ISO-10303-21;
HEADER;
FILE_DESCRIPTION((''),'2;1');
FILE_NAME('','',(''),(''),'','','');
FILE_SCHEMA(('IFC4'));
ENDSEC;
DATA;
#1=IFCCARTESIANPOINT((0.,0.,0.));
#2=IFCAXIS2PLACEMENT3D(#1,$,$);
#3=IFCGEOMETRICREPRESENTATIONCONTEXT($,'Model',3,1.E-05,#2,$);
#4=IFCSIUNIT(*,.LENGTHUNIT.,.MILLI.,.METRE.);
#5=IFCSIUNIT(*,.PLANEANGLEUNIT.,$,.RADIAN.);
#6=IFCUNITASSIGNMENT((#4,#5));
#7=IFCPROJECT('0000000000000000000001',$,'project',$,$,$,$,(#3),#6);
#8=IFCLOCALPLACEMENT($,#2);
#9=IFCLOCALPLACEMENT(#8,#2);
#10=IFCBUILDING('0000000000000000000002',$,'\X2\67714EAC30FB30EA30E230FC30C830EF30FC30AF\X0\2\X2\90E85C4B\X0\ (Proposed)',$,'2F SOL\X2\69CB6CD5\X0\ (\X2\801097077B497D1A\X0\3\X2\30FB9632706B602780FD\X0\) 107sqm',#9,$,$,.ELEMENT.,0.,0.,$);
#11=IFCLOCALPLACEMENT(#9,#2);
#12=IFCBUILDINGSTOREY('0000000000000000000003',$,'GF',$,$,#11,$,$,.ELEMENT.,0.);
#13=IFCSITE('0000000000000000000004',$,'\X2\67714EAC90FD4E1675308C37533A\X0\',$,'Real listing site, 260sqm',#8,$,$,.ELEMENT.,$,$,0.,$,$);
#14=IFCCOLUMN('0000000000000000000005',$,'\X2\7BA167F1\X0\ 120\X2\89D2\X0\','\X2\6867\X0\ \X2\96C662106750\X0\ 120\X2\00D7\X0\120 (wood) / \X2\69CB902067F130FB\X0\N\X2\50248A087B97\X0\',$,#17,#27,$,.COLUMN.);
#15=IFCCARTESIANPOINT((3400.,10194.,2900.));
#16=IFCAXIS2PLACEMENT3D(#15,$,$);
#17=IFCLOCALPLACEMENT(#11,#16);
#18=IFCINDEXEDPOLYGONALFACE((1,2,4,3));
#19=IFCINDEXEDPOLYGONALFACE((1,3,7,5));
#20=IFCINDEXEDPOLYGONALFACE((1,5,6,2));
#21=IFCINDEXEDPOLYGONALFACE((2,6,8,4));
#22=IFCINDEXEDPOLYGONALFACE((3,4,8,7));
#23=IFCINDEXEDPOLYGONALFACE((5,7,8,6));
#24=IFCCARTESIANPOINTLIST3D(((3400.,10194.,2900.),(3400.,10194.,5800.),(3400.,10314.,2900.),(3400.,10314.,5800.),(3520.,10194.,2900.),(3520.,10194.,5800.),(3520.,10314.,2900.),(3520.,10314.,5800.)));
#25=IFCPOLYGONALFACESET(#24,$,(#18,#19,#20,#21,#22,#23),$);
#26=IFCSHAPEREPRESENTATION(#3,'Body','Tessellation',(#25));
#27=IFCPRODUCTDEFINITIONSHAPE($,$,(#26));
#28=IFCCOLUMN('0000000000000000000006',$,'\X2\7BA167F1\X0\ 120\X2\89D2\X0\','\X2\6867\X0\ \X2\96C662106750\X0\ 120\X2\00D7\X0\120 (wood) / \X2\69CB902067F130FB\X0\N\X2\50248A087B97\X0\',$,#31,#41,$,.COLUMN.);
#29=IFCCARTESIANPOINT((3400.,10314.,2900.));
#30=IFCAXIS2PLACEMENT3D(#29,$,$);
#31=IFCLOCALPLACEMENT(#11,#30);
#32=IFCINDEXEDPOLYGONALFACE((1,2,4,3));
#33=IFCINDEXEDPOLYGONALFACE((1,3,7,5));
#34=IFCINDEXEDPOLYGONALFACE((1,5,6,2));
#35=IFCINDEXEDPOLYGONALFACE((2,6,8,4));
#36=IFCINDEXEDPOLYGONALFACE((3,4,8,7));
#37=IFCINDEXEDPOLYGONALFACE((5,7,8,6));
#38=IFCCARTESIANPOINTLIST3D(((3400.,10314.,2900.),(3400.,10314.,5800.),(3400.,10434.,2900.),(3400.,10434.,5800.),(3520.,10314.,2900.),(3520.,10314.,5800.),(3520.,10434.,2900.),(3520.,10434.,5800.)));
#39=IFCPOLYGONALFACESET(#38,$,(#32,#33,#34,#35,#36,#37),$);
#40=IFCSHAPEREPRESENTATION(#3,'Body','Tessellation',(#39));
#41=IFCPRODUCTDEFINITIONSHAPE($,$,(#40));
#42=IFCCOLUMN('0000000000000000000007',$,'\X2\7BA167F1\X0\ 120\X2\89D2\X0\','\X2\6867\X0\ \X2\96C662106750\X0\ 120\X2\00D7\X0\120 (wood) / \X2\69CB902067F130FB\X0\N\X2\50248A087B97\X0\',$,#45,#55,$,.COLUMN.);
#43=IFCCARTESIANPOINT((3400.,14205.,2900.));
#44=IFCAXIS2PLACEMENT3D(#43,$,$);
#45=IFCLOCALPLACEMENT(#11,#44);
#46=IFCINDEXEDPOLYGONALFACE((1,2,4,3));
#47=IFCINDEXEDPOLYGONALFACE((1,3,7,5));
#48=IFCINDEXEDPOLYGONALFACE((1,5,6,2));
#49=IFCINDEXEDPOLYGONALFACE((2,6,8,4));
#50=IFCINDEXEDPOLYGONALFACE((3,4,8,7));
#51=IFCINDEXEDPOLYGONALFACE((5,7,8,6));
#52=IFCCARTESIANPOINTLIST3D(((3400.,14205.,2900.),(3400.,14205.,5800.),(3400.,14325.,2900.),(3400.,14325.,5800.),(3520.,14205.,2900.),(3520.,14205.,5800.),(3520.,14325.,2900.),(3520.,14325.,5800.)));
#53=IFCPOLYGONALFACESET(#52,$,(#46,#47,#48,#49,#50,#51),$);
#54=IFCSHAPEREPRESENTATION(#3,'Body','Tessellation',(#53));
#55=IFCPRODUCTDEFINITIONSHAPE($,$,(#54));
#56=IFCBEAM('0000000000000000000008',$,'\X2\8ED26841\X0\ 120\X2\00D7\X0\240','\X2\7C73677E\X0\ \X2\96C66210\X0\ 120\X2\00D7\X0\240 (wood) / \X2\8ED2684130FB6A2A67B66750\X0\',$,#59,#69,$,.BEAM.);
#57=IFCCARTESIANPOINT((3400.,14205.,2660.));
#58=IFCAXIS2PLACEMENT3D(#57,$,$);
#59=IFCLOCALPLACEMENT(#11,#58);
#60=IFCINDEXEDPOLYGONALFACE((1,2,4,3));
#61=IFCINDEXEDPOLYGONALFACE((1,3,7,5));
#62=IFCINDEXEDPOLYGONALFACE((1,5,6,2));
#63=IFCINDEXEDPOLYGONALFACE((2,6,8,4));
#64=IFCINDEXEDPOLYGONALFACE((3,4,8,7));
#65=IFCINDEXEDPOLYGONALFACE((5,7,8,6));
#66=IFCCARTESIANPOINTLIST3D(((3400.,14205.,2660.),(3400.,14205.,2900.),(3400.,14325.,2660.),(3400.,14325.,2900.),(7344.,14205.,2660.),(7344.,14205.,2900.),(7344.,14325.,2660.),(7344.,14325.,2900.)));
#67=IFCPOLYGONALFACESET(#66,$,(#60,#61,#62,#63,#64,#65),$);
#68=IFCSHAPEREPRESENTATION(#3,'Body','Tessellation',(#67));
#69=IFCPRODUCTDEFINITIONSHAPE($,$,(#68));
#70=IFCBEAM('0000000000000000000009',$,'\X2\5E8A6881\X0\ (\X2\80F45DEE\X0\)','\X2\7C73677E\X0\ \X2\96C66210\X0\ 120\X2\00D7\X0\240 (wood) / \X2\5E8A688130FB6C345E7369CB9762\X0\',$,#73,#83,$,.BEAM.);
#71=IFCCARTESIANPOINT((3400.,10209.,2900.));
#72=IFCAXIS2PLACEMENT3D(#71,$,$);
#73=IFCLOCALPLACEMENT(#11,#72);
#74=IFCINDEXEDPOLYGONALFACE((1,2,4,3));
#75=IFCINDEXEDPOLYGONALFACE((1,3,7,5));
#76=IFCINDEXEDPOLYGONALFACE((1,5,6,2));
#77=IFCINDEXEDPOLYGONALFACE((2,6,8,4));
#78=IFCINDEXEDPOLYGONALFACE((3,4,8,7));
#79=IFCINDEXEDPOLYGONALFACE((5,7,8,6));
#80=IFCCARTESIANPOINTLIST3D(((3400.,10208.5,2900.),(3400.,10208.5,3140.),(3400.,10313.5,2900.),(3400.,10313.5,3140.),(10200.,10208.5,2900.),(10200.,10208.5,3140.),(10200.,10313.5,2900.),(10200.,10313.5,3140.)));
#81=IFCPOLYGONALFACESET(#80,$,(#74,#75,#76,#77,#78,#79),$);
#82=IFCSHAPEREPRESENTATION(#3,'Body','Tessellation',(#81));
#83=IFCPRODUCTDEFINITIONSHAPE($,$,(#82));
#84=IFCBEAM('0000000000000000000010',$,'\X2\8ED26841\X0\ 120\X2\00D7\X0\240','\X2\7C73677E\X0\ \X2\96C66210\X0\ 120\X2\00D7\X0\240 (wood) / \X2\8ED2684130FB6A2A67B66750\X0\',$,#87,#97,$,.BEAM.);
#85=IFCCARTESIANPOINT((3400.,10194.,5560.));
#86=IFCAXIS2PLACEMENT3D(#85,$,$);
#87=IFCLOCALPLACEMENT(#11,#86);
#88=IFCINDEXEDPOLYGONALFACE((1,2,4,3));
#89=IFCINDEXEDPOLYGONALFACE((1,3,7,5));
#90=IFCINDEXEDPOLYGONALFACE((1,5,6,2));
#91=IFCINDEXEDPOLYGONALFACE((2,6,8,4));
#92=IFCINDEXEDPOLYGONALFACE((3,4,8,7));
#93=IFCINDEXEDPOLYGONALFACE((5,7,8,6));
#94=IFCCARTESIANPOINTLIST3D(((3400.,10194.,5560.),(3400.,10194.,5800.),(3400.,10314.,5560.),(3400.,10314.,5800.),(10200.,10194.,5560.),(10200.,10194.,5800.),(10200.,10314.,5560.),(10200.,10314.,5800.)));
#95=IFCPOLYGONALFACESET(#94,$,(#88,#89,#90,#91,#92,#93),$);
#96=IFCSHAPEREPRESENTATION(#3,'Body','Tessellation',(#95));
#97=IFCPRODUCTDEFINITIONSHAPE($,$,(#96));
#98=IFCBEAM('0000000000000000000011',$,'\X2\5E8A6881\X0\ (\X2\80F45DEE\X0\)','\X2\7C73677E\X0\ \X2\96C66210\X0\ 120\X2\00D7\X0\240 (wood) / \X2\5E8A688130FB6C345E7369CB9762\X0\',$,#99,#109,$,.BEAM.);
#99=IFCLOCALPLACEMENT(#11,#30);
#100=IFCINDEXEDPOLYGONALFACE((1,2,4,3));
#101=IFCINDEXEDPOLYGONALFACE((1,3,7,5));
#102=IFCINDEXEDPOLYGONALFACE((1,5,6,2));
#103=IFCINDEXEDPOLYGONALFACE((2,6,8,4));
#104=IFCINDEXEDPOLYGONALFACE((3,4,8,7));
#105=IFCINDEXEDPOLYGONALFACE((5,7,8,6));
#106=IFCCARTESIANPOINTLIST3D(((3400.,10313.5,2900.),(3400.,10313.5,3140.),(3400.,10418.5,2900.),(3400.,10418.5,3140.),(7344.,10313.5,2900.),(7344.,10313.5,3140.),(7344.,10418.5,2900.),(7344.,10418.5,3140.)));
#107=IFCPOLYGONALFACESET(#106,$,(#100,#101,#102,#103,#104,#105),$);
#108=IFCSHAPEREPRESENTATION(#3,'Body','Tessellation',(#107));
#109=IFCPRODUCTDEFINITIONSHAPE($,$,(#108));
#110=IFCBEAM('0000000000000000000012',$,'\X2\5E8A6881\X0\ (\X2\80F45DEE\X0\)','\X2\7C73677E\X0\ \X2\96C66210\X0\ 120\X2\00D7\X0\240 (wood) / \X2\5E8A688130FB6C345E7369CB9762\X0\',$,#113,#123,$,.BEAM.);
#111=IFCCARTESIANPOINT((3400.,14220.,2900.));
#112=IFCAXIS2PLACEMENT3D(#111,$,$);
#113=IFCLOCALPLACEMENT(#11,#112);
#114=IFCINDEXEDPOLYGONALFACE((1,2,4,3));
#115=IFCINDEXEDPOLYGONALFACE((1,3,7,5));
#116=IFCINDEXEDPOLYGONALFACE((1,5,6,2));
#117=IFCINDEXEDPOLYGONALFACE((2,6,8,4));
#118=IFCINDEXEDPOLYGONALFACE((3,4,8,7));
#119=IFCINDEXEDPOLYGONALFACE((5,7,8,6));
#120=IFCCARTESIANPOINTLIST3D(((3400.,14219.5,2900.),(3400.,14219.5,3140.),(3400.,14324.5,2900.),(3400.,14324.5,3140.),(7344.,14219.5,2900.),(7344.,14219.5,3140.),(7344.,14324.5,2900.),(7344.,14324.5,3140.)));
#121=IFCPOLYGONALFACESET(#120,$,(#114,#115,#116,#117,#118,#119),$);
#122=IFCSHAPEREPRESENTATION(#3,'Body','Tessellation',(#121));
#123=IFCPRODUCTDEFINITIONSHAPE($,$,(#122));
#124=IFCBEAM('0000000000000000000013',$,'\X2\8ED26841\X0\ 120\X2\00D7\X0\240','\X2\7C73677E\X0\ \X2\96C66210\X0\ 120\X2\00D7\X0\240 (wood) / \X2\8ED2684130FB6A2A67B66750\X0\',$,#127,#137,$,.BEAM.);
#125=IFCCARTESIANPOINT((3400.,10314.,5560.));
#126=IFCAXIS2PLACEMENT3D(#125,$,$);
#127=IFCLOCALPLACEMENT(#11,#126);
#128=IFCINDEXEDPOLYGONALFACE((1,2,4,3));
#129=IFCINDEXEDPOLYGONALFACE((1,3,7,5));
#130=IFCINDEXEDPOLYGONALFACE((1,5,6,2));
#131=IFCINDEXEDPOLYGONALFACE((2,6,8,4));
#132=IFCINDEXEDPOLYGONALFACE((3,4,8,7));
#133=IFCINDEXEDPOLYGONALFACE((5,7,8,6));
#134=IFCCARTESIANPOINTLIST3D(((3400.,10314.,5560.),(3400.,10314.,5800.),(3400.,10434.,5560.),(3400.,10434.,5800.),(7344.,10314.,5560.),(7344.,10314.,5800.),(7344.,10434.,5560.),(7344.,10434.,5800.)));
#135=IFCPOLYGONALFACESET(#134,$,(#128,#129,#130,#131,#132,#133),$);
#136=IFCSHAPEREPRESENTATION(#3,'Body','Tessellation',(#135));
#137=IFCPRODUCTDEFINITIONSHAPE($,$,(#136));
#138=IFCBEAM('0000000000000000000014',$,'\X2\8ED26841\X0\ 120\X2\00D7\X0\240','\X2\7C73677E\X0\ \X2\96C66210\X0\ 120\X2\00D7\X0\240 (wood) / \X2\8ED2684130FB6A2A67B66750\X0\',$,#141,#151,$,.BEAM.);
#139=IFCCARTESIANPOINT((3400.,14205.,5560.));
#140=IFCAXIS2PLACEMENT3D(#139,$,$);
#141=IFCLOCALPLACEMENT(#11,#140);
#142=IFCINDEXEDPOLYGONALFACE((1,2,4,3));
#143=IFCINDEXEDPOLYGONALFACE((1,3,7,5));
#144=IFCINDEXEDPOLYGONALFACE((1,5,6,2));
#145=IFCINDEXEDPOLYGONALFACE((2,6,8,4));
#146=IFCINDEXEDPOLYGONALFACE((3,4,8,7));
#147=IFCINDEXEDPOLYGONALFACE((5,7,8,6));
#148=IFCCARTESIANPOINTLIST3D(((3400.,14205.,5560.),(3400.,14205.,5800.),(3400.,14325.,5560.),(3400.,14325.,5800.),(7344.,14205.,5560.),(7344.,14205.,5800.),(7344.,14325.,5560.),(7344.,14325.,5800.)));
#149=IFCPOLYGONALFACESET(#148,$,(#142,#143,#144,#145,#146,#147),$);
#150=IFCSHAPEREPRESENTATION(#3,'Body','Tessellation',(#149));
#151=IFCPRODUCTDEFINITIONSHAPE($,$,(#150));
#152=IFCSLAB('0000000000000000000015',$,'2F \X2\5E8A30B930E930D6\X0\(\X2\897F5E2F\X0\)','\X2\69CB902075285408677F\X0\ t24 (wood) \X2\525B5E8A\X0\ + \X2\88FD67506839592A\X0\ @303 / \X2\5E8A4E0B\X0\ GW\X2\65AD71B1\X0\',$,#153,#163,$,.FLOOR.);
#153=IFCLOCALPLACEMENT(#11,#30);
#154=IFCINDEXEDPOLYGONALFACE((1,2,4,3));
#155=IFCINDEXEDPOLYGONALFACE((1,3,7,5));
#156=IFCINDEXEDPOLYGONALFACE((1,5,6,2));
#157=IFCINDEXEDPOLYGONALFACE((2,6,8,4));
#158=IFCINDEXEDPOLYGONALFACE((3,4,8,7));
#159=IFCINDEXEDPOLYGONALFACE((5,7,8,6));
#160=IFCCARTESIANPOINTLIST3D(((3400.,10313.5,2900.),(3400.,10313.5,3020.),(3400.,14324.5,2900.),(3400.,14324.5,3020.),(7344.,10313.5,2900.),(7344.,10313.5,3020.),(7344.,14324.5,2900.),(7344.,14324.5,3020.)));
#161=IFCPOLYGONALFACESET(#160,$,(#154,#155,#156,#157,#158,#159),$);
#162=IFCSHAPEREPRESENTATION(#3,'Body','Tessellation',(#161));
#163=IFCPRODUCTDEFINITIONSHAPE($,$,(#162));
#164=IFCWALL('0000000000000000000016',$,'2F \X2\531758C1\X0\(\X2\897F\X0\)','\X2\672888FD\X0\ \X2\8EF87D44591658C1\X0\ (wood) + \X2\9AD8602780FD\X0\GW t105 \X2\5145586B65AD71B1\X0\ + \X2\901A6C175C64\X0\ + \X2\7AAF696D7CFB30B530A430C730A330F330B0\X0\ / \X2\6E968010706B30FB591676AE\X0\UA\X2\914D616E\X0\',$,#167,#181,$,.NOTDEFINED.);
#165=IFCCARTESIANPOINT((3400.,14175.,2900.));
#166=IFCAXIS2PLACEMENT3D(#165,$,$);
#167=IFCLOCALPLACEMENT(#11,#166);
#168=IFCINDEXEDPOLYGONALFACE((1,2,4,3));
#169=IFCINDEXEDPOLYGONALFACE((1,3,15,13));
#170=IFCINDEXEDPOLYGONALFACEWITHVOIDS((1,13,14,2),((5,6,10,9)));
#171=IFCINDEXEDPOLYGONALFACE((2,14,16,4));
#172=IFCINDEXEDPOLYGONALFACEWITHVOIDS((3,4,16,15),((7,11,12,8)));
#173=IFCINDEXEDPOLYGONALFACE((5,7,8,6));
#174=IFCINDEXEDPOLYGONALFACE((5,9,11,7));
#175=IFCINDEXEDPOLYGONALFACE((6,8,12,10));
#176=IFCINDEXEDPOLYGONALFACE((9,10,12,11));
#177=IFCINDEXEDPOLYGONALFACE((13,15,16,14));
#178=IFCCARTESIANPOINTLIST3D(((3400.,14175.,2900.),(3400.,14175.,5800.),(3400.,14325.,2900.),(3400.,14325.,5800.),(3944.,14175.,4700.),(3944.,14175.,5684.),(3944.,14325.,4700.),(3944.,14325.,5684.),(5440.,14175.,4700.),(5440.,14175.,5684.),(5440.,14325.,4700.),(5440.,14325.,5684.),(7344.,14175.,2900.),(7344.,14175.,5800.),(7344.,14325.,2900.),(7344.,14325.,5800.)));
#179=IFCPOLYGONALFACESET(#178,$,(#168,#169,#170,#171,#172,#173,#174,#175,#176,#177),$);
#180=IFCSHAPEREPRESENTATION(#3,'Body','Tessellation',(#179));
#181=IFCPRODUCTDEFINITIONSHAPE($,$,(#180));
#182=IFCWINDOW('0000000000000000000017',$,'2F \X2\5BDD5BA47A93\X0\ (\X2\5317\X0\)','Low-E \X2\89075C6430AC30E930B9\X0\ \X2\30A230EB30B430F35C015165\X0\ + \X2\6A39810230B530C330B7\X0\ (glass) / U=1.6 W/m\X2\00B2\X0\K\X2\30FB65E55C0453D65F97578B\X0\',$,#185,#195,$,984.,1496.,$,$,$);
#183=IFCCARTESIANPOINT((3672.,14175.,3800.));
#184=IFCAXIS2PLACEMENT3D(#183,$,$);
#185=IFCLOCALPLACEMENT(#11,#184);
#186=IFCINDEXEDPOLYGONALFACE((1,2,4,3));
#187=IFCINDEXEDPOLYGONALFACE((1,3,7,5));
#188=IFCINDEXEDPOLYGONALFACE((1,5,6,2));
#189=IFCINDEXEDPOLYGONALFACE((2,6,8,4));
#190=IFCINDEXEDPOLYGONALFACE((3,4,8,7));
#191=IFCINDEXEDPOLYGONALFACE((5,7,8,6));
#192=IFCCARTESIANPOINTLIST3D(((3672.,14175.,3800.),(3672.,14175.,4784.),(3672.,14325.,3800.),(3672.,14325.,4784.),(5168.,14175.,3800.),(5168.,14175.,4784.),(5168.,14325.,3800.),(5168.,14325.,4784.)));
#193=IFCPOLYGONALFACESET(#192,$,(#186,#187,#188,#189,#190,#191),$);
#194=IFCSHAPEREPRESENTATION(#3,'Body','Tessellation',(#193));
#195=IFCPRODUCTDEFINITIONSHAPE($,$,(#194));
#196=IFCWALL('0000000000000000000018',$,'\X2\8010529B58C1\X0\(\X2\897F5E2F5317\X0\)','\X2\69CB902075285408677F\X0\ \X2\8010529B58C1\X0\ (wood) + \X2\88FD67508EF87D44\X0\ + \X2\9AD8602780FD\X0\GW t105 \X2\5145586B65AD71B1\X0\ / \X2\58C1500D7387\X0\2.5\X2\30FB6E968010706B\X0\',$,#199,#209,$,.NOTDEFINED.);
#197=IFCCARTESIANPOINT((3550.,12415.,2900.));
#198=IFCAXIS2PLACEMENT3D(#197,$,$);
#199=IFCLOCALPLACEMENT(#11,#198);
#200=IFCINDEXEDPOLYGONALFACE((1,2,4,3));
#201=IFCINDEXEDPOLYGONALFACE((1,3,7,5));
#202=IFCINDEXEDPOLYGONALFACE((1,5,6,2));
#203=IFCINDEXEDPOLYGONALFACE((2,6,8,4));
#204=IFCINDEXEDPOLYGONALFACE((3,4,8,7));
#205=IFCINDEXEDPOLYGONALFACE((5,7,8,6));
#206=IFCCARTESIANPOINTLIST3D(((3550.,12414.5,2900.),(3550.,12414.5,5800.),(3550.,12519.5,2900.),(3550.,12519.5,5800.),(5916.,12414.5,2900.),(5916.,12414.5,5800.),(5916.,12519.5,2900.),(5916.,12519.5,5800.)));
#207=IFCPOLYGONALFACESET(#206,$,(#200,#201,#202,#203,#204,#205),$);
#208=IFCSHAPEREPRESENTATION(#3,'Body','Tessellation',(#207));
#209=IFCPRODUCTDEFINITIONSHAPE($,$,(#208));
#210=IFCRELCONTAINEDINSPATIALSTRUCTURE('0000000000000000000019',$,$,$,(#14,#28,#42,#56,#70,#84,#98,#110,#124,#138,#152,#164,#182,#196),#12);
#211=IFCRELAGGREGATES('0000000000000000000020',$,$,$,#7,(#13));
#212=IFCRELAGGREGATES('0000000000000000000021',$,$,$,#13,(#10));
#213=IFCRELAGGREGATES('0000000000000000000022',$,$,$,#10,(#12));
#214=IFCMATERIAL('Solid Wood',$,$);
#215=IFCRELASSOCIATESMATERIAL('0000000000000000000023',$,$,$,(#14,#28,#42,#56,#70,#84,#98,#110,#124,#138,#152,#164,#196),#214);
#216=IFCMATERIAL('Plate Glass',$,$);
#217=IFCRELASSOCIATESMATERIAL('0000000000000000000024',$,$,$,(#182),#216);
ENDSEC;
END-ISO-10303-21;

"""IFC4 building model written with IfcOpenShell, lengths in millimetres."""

from ifc_helpers import new_model, si_unit, frame, frame_2d, origin, place, context, project, spatial, rectangle, extrude, material, element, fill, save


model = new_model("IFC4")

# Units and contexts
model_context = context("Model", 3, precision=1e-05, world=origin())
ifc_project = project(units=[si_unit("LENGTHUNIT", "METRE", prefix="MILLI"), si_unit("PLANEANGLEUNIT", "RADIAN")], contexts=[model_context])

# Site, building, storey
site_placement = place(None, origin())
site = spatial("IfcSite", under=ifc_project, at=site_placement, Name="東京都世田谷区", ObjectType="Real listing site, 260sqm", CompositionType="ELEMENT", RefElevation=0.0)
building_placement = place(site_placement, origin())
building = spatial("IfcBuilding", under=site, at=building_placement, Name="東京・リモートワーク2部屋 (Proposed)", ObjectType="2F SOL構法 (耐震等級3・防火性能) 107sqm", CompositionType="ELEMENT", ElevationOfRefHeight=0.0, ElevationOfTerrain=0.0)
storey_placement = place(building_placement, origin())
storey = spatial("IfcBuildingStorey", under=building, at=storey_placement, Name="GF", CompositionType="ELEMENT", Elevation=0.0)

# Columns
ifc_material_1 = material(Name="Solid Wood")
column_1_placement = place(storey_placement, frame((3400.0, 10194.0, 2900.0)))
element("IfcColumn", 1, at=column_1_placement, inside=storey, material=ifc_material_1, Name="管柱 120角", Description="桧 集成材 120×120 (wood) / 構造柱・N値計算", PredefinedType="COLUMN", context=model_context, shape_type="SweptSolid", body=[
    extrude(rectangle(XDim=120.0, YDim=120.0, at=frame_2d((60.0, 60.0))), frame((3400.0, 10194.0, 2900.0)), (0.0, 0.0, 1.0), 2900.0),
])
column_2_placement = place(storey_placement, frame((3400.0, 10314.0, 2900.0)))
element("IfcColumn", 2, at=column_2_placement, inside=storey, material=ifc_material_1, Name="管柱 120角", Description="桧 集成材 120×120 (wood) / 構造柱・N値計算", PredefinedType="COLUMN", context=model_context, shape_type="SweptSolid", body=[
    extrude(rectangle(XDim=120.0, YDim=120.0, at=frame_2d((60.0, 60.0))), frame((3400.0, 10314.0, 2900.0)), (0.0, 0.0, 1.0), 2900.0),
])
column_3_placement = place(storey_placement, frame((3400.0, 14205.0, 2900.0)))
element("IfcColumn", 3, at=column_3_placement, inside=storey, material=ifc_material_1, Name="管柱 120角", Description="桧 集成材 120×120 (wood) / 構造柱・N値計算", PredefinedType="COLUMN", context=model_context, shape_type="SweptSolid", body=[
    extrude(rectangle(XDim=120.0, YDim=120.0, at=frame_2d((60.0, 60.0))), frame((3400.0, 14205.0, 2900.0)), (0.0, 0.0, 1.0), 2900.0),
])

# Beams
beam_1_placement = place(storey_placement, frame((3400.0, 14205.0, 2660.0)))
element("IfcBeam", 4, at=beam_1_placement, inside=storey, material=ifc_material_1, Name="軒桁 120×240", Description="米松 集成 120×240 (wood) / 軒桁・横架材", PredefinedType="BEAM", context=model_context, shape_type="SweptSolid", body=[
    extrude(rectangle(XDim=3944.0, YDim=120.0, at=frame_2d((1972.0, 60.0))), frame((3400.0, 14205.0, 2660.0)), (0.0, 0.0, 1.0), 240.0),
])
beam_2_placement = place(storey_placement, frame((3400.0, 10209.0, 2900.0)))
element("IfcBeam", 5, at=beam_2_placement, inside=storey, material=ifc_material_1, Name="床梁 (胴差)", Description="米松 集成 120×240 (wood) / 床梁・水平構面", PredefinedType="BEAM", context=model_context, shape_type="SweptSolid", body=[
    extrude(rectangle(XDim=6800.0, YDim=105.0, at=frame_2d((3400.0, 52.0))), frame((3400.0, 10209.0, 2900.0)), (0.0, 0.0, 1.0), 240.0),
])
beam_3_placement = place(storey_placement, frame((3400.0, 10194.0, 5560.0)))
element("IfcBeam", 6, at=beam_3_placement, inside=storey, material=ifc_material_1, Name="軒桁 120×240", Description="米松 集成 120×240 (wood) / 軒桁・横架材", PredefinedType="BEAM", context=model_context, shape_type="SweptSolid", body=[
    extrude(rectangle(XDim=6800.0, YDim=120.0, at=frame_2d((3400.0, 60.0))), frame((3400.0, 10194.0, 5560.0)), (0.0, 0.0, 1.0), 240.0),
])
beam_4_placement = place(storey_placement, frame((3400.0, 10314.0, 2900.0)))
element("IfcBeam", 7, at=beam_4_placement, inside=storey, material=ifc_material_1, Name="床梁 (胴差)", Description="米松 集成 120×240 (wood) / 床梁・水平構面", PredefinedType="BEAM", context=model_context, shape_type="SweptSolid", body=[
    extrude(rectangle(XDim=3944.0, YDim=105.0, at=frame_2d((1972.0, 52.0))), frame((3400.0, 10314.0, 2900.0)), (0.0, 0.0, 1.0), 240.0),
])
beam_5_placement = place(storey_placement, frame((3400.0, 14220.0, 2900.0)))
element("IfcBeam", 8, at=beam_5_placement, inside=storey, material=ifc_material_1, Name="床梁 (胴差)", Description="米松 集成 120×240 (wood) / 床梁・水平構面", PredefinedType="BEAM", context=model_context, shape_type="SweptSolid", body=[
    extrude(rectangle(XDim=3944.0, YDim=105.0, at=frame_2d((1972.0, 52.0))), frame((3400.0, 14220.0, 2900.0)), (0.0, 0.0, 1.0), 240.0),
])
beam_6_placement = place(storey_placement, frame((3400.0, 10314.0, 5560.0)))
element("IfcBeam", 9, at=beam_6_placement, inside=storey, material=ifc_material_1, Name="軒桁 120×240", Description="米松 集成 120×240 (wood) / 軒桁・横架材", PredefinedType="BEAM", context=model_context, shape_type="SweptSolid", body=[
    extrude(rectangle(XDim=3944.0, YDim=120.0, at=frame_2d((1972.0, 60.0))), frame((3400.0, 10314.0, 5560.0)), (0.0, 0.0, 1.0), 240.0),
])
beam_7_placement = place(storey_placement, frame((3400.0, 14205.0, 5560.0)))
element("IfcBeam", 10, at=beam_7_placement, inside=storey, material=ifc_material_1, Name="軒桁 120×240", Description="米松 集成 120×240 (wood) / 軒桁・横架材", PredefinedType="BEAM", context=model_context, shape_type="SweptSolid", body=[
    extrude(rectangle(XDim=3944.0, YDim=120.0, at=frame_2d((1972.0, 60.0))), frame((3400.0, 14205.0, 5560.0)), (0.0, 0.0, 1.0), 240.0),
])

# Slab
slab_placement = place(storey_placement, frame((3400.0, 10314.0, 2900.0)))
element("IfcSlab", 11, at=slab_placement, inside=storey, material=ifc_material_1, Name="2F 床スラブ(西帯)", Description="構造用合板 t24 (wood) 剛床 + 製材根太 @303 / 床下 GW断熱", PredefinedType="FLOOR", context=model_context, shape_type="SweptSolid", body=[
    extrude(rectangle(XDim=3944.0, YDim=4011.0, at=frame_2d((1972.0, 2005.0))), frame((3400.0, 10314.0, 2900.0)), (0.0, 0.0, 1.0), 120.0),
])

# Wall, opening, window
wall_1_placement = place(storey_placement, frame((3400.0, 14175.0, 2900.0)))
wall_1 = element("IfcWall", 12, at=wall_1_placement, inside=storey, material=ifc_material_1, Name="2F 北壁(西)", Description="木製 軸組外壁 (wood) + 高性能GW t105 充填断熱 + 通気層 + 窯業系サイディング / 準耐火・外皮UA配慮", PredefinedType="NOTDEFINED", context=model_context, shape_type="SweptSolid", body=[
    extrude(rectangle(XDim=3944.0, YDim=150.0, at=frame_2d((1972.0, 75.0))), frame((3400.0, 14175.0, 2900.0)), (0.0, 0.0, 1.0), 2900.0),
])
opening_placement = place(storey_placement, frame((3672.0, 14175.0, 3800.0)))
opening = element("IfcOpeningElement", 13, at=opening_placement, cuts=wall_1, PredefinedType="NOTDEFINED", context=model_context, shape_type="SweptSolid", body=[
    extrude(rectangle(XDim=1496.0, YDim=150.0, at=frame_2d((748.0, 75.0))), frame((3672.0, 14175.0, 3800.0)), (0.0, 0.0, 1.0), 984.0),
])
ifc_material_2 = material(Name="Plate Glass")
window_placement = place(storey_placement, frame((3672.0, 14175.0, 3800.0)))
window = element("IfcWindow", 14, at=window_placement, inside=storey, material=ifc_material_2, Name="2F 寝室窓 (北)", Description="Low-E 複層ガラス アルゴン封入 + 樹脂サッシ (glass) / U=1.6 W/m²K・日射取得型", OverallHeight=984.0, OverallWidth=1496.0, context=model_context, shape_type="SweptSolid", body=[
    extrude(rectangle(XDim=1496.0, YDim=150.0, at=frame_2d((748.0, 75.0))), frame((3672.0, 14175.0, 3800.0)), (0.0, 0.0, 1.0), 984.0),
])
fill(opening, window)

# Wall
wall_2_placement = place(storey_placement, frame((3550.0, 12415.0, 2900.0)))
element("IfcWall", 15, at=wall_2_placement, inside=storey, material=ifc_material_1, Name="耐力壁(西帯北)", Description="構造用合板 耐力壁 (wood) + 製材軸組 + 高性能GW t105 充填断熱 / 壁倍率2.5・準耐火", PredefinedType="NOTDEFINED", context=model_context, shape_type="SweptSolid", body=[
    extrude(rectangle(XDim=2366.0, YDim=105.0, at=frame_2d((1183.0, 52.0))), frame((3550.0, 12415.0, 2900.0)), (0.0, 0.0, 1.0), 2900.0),
])

save(model, "model.ifc")
